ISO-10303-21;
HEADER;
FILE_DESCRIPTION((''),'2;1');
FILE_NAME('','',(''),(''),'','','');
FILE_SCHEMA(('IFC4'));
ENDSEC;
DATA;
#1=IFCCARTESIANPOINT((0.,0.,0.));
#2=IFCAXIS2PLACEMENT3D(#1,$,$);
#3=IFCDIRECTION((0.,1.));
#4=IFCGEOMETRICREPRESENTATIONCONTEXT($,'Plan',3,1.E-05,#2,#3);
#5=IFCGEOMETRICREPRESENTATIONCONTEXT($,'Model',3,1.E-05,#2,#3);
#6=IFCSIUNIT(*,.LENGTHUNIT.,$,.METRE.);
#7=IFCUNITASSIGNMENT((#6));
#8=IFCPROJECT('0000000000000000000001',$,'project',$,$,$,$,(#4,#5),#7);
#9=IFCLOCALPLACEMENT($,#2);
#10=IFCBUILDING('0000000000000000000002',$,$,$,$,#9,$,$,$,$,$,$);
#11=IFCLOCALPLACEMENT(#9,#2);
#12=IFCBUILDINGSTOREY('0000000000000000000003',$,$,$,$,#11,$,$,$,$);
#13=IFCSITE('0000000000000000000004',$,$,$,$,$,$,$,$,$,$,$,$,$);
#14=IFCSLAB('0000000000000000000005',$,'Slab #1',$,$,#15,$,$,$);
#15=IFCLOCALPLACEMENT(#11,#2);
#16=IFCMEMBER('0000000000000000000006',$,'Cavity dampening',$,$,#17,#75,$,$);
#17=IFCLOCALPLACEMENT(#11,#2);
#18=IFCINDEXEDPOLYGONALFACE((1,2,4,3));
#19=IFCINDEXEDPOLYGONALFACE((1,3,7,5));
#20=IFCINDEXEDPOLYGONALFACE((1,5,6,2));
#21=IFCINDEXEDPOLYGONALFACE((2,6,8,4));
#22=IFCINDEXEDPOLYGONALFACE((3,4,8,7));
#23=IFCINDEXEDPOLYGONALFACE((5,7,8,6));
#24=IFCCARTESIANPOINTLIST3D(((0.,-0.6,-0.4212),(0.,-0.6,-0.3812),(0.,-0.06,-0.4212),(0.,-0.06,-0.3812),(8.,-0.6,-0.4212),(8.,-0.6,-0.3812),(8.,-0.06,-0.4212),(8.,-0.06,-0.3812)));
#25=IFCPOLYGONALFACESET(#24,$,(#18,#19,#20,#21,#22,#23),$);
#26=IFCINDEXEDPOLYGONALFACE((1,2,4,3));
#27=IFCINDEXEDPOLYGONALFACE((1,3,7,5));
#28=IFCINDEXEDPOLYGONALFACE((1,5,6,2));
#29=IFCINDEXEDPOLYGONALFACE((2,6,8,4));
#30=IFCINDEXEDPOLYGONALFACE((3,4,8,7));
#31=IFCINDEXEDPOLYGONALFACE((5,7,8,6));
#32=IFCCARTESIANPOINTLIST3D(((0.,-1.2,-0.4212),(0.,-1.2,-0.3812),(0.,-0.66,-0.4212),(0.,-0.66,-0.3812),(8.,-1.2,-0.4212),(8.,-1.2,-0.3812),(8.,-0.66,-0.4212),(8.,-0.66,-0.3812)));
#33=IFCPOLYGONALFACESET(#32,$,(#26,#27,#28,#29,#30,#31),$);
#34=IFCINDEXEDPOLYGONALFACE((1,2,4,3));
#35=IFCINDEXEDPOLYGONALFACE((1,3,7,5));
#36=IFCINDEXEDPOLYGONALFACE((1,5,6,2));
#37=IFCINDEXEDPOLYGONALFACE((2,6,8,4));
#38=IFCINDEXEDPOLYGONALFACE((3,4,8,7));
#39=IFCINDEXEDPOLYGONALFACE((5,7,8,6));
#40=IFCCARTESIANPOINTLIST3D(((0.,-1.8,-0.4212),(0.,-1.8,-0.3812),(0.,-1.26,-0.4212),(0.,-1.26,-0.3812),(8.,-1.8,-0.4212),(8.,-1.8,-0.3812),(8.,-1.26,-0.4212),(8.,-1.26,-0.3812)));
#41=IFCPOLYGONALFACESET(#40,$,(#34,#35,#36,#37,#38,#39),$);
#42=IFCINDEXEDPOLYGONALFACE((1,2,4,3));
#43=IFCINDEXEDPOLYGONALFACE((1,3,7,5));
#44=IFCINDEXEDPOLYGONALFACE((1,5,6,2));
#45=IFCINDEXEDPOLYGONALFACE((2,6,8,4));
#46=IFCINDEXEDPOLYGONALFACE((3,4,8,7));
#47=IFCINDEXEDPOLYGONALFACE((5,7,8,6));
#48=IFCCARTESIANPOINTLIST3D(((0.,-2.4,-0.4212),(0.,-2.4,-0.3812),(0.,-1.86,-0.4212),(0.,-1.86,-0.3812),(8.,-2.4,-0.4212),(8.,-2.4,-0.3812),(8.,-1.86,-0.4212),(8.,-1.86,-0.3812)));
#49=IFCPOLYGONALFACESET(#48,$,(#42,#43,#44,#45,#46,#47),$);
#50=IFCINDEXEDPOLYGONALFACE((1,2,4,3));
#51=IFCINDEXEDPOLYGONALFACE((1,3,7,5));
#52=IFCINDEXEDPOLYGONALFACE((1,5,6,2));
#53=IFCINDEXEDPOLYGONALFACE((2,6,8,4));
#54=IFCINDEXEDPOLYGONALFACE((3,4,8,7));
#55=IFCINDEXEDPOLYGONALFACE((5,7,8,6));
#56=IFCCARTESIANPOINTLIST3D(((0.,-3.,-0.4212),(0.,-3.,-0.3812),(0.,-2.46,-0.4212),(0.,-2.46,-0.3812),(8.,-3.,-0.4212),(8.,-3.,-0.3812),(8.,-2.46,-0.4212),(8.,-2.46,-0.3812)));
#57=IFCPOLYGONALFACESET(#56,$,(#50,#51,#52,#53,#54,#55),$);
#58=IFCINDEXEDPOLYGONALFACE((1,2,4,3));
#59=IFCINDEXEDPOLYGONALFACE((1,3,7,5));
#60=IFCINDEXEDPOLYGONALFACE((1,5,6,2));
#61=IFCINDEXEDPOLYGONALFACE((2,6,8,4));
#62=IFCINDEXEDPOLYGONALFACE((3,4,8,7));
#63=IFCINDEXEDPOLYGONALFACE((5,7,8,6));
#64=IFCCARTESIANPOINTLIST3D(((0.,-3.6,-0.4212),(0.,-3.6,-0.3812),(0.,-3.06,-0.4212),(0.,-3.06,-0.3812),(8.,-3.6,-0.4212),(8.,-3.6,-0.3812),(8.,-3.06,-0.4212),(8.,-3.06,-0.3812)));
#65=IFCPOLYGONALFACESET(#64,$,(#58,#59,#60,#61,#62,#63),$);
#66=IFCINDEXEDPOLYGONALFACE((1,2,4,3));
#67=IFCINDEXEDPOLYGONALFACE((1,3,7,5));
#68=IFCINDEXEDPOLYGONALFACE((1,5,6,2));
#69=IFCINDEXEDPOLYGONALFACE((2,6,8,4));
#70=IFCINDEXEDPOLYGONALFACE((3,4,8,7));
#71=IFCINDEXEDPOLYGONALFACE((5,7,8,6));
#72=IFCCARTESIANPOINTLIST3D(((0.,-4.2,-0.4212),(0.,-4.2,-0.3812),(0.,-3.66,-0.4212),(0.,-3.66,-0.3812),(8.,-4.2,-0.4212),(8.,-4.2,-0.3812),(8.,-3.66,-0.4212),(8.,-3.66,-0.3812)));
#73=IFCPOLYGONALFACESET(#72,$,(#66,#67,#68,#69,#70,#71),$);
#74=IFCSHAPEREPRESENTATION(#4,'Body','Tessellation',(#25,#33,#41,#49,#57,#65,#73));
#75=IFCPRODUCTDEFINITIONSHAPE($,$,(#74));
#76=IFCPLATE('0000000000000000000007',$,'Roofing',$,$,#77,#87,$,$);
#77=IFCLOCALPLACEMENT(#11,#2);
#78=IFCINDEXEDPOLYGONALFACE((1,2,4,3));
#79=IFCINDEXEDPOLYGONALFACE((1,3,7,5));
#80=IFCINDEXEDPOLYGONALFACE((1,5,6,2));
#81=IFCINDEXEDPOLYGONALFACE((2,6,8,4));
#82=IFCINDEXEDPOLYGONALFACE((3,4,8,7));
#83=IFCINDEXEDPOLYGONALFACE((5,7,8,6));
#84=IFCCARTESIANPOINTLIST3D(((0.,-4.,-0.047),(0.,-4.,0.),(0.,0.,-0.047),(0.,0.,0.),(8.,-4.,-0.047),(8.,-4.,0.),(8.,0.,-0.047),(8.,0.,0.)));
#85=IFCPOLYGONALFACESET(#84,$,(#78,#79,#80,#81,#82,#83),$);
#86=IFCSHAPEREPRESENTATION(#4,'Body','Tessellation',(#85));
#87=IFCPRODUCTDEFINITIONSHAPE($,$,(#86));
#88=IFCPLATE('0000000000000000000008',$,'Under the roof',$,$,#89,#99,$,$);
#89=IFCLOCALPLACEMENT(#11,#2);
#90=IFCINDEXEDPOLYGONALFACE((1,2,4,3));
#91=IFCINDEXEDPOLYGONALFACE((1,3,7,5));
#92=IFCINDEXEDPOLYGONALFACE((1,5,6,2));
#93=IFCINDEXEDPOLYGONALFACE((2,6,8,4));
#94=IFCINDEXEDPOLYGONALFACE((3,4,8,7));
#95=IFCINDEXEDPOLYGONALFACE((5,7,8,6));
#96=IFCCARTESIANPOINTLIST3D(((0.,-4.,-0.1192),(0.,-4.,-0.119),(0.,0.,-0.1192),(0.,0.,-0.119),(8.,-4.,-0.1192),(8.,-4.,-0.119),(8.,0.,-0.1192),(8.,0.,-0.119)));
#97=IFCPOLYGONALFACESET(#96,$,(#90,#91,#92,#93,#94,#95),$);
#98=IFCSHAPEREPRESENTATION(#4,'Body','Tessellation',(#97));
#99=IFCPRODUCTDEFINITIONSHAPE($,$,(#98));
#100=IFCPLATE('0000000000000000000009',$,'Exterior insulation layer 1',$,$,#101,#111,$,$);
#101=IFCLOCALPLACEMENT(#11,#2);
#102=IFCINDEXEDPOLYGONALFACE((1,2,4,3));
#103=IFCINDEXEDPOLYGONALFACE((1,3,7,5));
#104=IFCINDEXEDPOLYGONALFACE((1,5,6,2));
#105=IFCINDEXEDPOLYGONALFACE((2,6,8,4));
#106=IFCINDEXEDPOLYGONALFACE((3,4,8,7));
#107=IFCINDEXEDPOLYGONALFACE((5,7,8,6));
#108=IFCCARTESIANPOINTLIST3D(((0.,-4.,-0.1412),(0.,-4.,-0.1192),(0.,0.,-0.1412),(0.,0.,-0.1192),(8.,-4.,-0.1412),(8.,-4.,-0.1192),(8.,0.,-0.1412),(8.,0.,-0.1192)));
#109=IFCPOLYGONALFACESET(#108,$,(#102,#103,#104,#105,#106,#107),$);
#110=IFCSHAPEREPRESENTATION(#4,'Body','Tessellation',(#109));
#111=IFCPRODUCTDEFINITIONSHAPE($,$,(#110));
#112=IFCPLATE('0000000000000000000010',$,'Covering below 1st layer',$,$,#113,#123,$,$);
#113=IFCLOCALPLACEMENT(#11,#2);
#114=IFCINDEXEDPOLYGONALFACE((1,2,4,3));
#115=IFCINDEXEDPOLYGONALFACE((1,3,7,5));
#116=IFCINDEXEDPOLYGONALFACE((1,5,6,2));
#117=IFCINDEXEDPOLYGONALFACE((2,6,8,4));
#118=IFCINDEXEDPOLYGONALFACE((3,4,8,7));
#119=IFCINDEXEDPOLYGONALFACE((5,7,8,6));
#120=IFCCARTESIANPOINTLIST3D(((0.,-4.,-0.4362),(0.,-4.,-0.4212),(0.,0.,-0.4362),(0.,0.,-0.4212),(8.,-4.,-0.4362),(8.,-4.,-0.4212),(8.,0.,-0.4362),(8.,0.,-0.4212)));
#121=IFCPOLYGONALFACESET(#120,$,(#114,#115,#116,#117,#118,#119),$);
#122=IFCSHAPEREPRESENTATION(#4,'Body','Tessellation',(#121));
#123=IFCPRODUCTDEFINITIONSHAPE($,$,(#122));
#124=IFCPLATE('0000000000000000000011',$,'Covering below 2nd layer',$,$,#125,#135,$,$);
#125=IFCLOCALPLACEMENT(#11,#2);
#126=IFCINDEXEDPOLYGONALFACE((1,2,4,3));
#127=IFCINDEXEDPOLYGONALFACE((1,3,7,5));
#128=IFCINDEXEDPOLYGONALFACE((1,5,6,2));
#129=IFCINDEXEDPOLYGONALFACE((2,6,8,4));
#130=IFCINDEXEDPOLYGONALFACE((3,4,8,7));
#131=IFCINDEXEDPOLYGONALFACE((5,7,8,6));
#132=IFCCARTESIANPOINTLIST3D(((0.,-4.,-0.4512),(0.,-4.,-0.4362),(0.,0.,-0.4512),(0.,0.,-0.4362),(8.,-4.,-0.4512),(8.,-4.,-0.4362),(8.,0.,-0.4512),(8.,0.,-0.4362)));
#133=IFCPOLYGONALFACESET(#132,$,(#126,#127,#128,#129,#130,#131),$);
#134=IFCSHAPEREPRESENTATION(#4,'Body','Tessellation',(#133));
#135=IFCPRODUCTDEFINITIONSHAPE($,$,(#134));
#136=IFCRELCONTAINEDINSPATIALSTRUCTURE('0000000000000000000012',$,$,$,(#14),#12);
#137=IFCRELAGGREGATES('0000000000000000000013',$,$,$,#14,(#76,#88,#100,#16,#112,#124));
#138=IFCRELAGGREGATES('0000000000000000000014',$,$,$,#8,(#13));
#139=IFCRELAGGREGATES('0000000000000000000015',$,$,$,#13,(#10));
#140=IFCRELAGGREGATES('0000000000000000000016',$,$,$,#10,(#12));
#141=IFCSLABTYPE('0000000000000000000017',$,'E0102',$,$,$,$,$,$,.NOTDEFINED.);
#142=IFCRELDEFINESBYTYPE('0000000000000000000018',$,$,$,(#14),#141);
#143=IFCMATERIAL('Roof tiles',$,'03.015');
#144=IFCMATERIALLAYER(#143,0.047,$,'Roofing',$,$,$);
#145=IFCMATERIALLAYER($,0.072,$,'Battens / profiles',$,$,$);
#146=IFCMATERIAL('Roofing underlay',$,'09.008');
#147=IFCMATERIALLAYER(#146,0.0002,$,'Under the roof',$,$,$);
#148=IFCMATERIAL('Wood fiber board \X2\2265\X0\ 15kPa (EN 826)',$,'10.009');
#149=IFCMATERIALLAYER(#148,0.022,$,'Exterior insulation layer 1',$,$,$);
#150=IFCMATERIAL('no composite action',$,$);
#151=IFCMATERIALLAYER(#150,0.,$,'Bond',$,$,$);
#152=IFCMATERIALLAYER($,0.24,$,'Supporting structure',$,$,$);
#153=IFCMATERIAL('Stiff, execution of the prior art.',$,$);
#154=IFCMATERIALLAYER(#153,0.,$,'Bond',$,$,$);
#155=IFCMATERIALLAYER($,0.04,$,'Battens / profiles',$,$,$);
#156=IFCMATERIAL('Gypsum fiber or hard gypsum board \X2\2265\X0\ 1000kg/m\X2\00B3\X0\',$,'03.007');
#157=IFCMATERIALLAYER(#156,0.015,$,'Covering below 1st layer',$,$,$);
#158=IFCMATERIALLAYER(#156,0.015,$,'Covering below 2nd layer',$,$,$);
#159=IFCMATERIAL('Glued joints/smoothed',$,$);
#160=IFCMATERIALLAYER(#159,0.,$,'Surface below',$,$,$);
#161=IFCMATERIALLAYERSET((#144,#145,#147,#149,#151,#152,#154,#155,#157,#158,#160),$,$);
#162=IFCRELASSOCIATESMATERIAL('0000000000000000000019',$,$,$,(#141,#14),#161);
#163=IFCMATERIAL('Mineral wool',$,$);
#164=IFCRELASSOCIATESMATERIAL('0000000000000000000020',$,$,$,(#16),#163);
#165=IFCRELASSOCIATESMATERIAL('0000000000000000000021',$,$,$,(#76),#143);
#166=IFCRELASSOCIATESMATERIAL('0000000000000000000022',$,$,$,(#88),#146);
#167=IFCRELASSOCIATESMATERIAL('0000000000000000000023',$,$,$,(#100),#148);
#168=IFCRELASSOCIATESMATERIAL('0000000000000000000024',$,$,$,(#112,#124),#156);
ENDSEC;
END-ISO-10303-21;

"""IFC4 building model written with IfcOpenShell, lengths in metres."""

from ifc_helpers import new_model, si_unit, direction, frame, frame_2d, origin, origin_with_axes, place, context, project, spatial, rectangle, extrude, material, layer, layer_set, type_object, element, aggregate, save


model = new_model("IFC4")

# Units and contexts
plan_context = context("Plan", 3, precision=1e-05, world=origin(), true_north=direction((0.0, 1.0)))
model_context = context("Model", 3, precision=1e-05, world=origin(), true_north=direction((0.0, 1.0)))
ifc_project = project(units=[si_unit("LENGTHUNIT", "METRE")], contexts=[plan_context, model_context])

# Site, building, storey
site = spatial("IfcSite", under=ifc_project)
building_placement = place(None, origin())
building = spatial("IfcBuilding", under=site, at=building_placement)
storey_placement = place(building_placement, origin())
storey = spatial("IfcBuildingStorey", under=building, at=storey_placement)

# Slab, member, plates
ifc_material_1 = material(Name="Roof tiles", Category="03.015")
ifc_layer_1 = layer(ifc_material_1, 0.047, Name="Roofing")
ifc_layer_2 = layer(None, 0.072, Name="Battens / profiles")
ifc_material_2 = material(Name="Roofing underlay", Category="09.008")
ifc_layer_3 = layer(ifc_material_2, 0.0002, Name="Under the roof")
ifc_material_3 = material(Name="Wood fiber board ≥ 15kPa (EN 826)", Category="10.009")
ifc_layer_4 = layer(ifc_material_3, 0.022, Name="Exterior insulation layer 1")
ifc_material_4 = material(Name="no composite action")
ifc_layer_5 = layer(ifc_material_4, 0.0, Name="Bond")
ifc_layer_6 = layer(None, 0.24, Name="Supporting structure")
ifc_material_5 = material(Name="Stiff, execution of the prior art.")
ifc_layer_7 = layer(ifc_material_5, 0.0, Name="Bond")
ifc_layer_8 = layer(None, 0.04, Name="Battens / profiles")
ifc_material_6 = material(Name="Gypsum fiber or hard gypsum board ≥ 1000kg/m³", Category="03.007")
ifc_layer_9 = layer(ifc_material_6, 0.015, Name="Covering below 1st layer")
ifc_layer_10 = layer(ifc_material_6, 0.015, Name="Covering below 2nd layer")
ifc_material_7 = material(Name="Glued joints/smoothed")
ifc_layer_11 = layer(ifc_material_7, 0.0, Name="Surface below")
ifc_layer_set = layer_set([ifc_layer_1, ifc_layer_2, ifc_layer_3, ifc_layer_4, ifc_layer_5, ifc_layer_6, ifc_layer_7, ifc_layer_8, ifc_layer_9, ifc_layer_10, ifc_layer_11])
slab_type = type_object("IfcSlabType", Name="E0102", PredefinedType="NOTDEFINED", material=ifc_layer_set)
slab_placement = place(None, frame((0.0, 0.0, 0.0), z_axis=(0.0, 0.0, -1.0), x_axis=(1.0, 0.0, 0.0)))
slab = element("IfcSlab", 1, at=slab_placement, inside=storey, type_object=slab_type, material=ifc_layer_set, Name="Slab #1")
ifc_material_8 = material(Name="Mineral wool")
member_1_placement = place(slab_placement, origin())
member_1 = element("IfcMember", 2, at=member_1_placement, material=ifc_material_8, Name="Cavity dampening", context=plan_context, shape_type="SweptSolid", body=[
    extrude(rectangle(XDim=0.54, YDim=0.04, at=frame_2d((0.27, 0.02), x_axis=(1.0, 0.0))), frame((0.0, 0.06, 0.3812), z_axis=(1.0, 0.0, 0.0), x_axis=(0.0, 1.0, 0.0)), (0.0, 0.0, 1.0), 8.0),
    extrude(rectangle(XDim=0.54, YDim=0.04, at=frame_2d((0.27, 0.02), x_axis=(1.0, 0.0))), frame((0.0, 0.66, 0.3812), z_axis=(1.0, 0.0, 0.0), x_axis=(0.0, 1.0, 0.0)), (0.0, 0.0, 1.0), 8.0),
    extrude(rectangle(XDim=0.54, YDim=0.04, at=frame_2d((0.27, 0.02), x_axis=(1.0, 0.0))), frame((0.0, 1.26, 0.3812), z_axis=(1.0, 0.0, 0.0), x_axis=(0.0, 1.0, 0.0)), (0.0, 0.0, 1.0), 8.0),
    extrude(rectangle(XDim=0.54, YDim=0.04, at=frame_2d((0.27, 0.02), x_axis=(1.0, 0.0))), frame((0.0, 1.86, 0.3812), z_axis=(1.0, 0.0, 0.0), x_axis=(0.0, 1.0, 0.0)), (0.0, 0.0, 1.0), 8.0),
    extrude(rectangle(XDim=0.54, YDim=0.04, at=frame_2d((0.27, 0.02), x_axis=(1.0, 0.0))), frame((0.0, 2.46, 0.3812), z_axis=(1.0, 0.0, 0.0), x_axis=(0.0, 1.0, 0.0)), (0.0, 0.0, 1.0), 8.0),
    extrude(rectangle(XDim=0.54, YDim=0.04, at=frame_2d((0.27, 0.02), x_axis=(1.0, 0.0))), frame((0.0, 3.06, 0.3812), z_axis=(1.0, 0.0, 0.0), x_axis=(0.0, 1.0, 0.0)), (0.0, 0.0, 1.0), 8.0),
    extrude(rectangle(XDim=0.54, YDim=0.04, at=frame_2d((0.27, 0.02), x_axis=(1.0, 0.0))), frame((0.0, 3.66, 0.3812), z_axis=(1.0, 0.0, 0.0), x_axis=(0.0, 1.0, 0.0)), (0.0, 0.0, 1.0), 8.0),
])
plate_1_placement = place(slab_placement, origin())
plate_1 = element("IfcPlate", 3, at=plate_1_placement, material=ifc_material_1, Name="Roofing", context=plan_context, shape_type="SweptSolid", body=[
    extrude(rectangle(XDim=8.0, YDim=4.0, at=frame_2d((4.0, 2.0), x_axis=(1.0, 0.0))), origin_with_axes(), (0.0, 0.0, 1.0), 0.047),
])
plate_2_placement = place(slab_placement, origin())
plate_2 = element("IfcPlate", 4, at=plate_2_placement, material=ifc_material_2, Name="Under the roof", context=plan_context, shape_type="SweptSolid", body=[
    extrude(rectangle(XDim=8.0, YDim=4.0, at=frame_2d((4.0, 2.0), x_axis=(1.0, 0.0))), frame((0.0, 0.0, 0.119), z_axis=(0.0, 0.0, 1.0), x_axis=(1.0, 0.0, 0.0)), (0.0, 0.0, 1.0), 0.0002),
])
plate_3_placement = place(slab_placement, origin())
plate_3 = element("IfcPlate", 5, at=plate_3_placement, material=ifc_material_3, Name="Exterior insulation layer 1", context=plan_context, shape_type="SweptSolid", body=[
    extrude(rectangle(XDim=8.0, YDim=4.0, at=frame_2d((4.0, 2.0), x_axis=(1.0, 0.0))), frame((0.0, 0.0, 0.1192), z_axis=(0.0, 0.0, 1.0), x_axis=(1.0, 0.0, 0.0)), (0.0, 0.0, 1.0), 0.022),
])
plate_4_placement = place(slab_placement, origin())
plate_4 = element("IfcPlate", 6, at=plate_4_placement, material=ifc_material_6, Name="Covering below 1st layer", context=plan_context, shape_type="SweptSolid", body=[
    extrude(rectangle(XDim=8.0, YDim=4.0, at=frame_2d((4.0, 2.0), x_axis=(1.0, 0.0))), frame((0.0, 0.0, 0.4212), z_axis=(0.0, 0.0, 1.0), x_axis=(1.0, 0.0, 0.0)), (0.0, 0.0, 1.0), 0.015),
])
plate_5_placement = place(slab_placement, origin())
plate_5 = element("IfcPlate", 7, at=plate_5_placement, material=ifc_material_6, Name="Covering below 2nd layer", context=plan_context, shape_type="SweptSolid", body=[
    extrude(rectangle(XDim=8.0, YDim=4.0, at=frame_2d((4.0, 2.0), x_axis=(1.0, 0.0))), frame((0.0, 0.0, 0.4362), z_axis=(0.0, 0.0, 1.0), x_axis=(1.0, 0.0, 0.0)), (0.0, 0.0, 1.0), 0.015),
])
aggregate(slab, [plate_1, plate_2, plate_3, member_1, plate_4, plate_5])

save(model, "model.ifc")
